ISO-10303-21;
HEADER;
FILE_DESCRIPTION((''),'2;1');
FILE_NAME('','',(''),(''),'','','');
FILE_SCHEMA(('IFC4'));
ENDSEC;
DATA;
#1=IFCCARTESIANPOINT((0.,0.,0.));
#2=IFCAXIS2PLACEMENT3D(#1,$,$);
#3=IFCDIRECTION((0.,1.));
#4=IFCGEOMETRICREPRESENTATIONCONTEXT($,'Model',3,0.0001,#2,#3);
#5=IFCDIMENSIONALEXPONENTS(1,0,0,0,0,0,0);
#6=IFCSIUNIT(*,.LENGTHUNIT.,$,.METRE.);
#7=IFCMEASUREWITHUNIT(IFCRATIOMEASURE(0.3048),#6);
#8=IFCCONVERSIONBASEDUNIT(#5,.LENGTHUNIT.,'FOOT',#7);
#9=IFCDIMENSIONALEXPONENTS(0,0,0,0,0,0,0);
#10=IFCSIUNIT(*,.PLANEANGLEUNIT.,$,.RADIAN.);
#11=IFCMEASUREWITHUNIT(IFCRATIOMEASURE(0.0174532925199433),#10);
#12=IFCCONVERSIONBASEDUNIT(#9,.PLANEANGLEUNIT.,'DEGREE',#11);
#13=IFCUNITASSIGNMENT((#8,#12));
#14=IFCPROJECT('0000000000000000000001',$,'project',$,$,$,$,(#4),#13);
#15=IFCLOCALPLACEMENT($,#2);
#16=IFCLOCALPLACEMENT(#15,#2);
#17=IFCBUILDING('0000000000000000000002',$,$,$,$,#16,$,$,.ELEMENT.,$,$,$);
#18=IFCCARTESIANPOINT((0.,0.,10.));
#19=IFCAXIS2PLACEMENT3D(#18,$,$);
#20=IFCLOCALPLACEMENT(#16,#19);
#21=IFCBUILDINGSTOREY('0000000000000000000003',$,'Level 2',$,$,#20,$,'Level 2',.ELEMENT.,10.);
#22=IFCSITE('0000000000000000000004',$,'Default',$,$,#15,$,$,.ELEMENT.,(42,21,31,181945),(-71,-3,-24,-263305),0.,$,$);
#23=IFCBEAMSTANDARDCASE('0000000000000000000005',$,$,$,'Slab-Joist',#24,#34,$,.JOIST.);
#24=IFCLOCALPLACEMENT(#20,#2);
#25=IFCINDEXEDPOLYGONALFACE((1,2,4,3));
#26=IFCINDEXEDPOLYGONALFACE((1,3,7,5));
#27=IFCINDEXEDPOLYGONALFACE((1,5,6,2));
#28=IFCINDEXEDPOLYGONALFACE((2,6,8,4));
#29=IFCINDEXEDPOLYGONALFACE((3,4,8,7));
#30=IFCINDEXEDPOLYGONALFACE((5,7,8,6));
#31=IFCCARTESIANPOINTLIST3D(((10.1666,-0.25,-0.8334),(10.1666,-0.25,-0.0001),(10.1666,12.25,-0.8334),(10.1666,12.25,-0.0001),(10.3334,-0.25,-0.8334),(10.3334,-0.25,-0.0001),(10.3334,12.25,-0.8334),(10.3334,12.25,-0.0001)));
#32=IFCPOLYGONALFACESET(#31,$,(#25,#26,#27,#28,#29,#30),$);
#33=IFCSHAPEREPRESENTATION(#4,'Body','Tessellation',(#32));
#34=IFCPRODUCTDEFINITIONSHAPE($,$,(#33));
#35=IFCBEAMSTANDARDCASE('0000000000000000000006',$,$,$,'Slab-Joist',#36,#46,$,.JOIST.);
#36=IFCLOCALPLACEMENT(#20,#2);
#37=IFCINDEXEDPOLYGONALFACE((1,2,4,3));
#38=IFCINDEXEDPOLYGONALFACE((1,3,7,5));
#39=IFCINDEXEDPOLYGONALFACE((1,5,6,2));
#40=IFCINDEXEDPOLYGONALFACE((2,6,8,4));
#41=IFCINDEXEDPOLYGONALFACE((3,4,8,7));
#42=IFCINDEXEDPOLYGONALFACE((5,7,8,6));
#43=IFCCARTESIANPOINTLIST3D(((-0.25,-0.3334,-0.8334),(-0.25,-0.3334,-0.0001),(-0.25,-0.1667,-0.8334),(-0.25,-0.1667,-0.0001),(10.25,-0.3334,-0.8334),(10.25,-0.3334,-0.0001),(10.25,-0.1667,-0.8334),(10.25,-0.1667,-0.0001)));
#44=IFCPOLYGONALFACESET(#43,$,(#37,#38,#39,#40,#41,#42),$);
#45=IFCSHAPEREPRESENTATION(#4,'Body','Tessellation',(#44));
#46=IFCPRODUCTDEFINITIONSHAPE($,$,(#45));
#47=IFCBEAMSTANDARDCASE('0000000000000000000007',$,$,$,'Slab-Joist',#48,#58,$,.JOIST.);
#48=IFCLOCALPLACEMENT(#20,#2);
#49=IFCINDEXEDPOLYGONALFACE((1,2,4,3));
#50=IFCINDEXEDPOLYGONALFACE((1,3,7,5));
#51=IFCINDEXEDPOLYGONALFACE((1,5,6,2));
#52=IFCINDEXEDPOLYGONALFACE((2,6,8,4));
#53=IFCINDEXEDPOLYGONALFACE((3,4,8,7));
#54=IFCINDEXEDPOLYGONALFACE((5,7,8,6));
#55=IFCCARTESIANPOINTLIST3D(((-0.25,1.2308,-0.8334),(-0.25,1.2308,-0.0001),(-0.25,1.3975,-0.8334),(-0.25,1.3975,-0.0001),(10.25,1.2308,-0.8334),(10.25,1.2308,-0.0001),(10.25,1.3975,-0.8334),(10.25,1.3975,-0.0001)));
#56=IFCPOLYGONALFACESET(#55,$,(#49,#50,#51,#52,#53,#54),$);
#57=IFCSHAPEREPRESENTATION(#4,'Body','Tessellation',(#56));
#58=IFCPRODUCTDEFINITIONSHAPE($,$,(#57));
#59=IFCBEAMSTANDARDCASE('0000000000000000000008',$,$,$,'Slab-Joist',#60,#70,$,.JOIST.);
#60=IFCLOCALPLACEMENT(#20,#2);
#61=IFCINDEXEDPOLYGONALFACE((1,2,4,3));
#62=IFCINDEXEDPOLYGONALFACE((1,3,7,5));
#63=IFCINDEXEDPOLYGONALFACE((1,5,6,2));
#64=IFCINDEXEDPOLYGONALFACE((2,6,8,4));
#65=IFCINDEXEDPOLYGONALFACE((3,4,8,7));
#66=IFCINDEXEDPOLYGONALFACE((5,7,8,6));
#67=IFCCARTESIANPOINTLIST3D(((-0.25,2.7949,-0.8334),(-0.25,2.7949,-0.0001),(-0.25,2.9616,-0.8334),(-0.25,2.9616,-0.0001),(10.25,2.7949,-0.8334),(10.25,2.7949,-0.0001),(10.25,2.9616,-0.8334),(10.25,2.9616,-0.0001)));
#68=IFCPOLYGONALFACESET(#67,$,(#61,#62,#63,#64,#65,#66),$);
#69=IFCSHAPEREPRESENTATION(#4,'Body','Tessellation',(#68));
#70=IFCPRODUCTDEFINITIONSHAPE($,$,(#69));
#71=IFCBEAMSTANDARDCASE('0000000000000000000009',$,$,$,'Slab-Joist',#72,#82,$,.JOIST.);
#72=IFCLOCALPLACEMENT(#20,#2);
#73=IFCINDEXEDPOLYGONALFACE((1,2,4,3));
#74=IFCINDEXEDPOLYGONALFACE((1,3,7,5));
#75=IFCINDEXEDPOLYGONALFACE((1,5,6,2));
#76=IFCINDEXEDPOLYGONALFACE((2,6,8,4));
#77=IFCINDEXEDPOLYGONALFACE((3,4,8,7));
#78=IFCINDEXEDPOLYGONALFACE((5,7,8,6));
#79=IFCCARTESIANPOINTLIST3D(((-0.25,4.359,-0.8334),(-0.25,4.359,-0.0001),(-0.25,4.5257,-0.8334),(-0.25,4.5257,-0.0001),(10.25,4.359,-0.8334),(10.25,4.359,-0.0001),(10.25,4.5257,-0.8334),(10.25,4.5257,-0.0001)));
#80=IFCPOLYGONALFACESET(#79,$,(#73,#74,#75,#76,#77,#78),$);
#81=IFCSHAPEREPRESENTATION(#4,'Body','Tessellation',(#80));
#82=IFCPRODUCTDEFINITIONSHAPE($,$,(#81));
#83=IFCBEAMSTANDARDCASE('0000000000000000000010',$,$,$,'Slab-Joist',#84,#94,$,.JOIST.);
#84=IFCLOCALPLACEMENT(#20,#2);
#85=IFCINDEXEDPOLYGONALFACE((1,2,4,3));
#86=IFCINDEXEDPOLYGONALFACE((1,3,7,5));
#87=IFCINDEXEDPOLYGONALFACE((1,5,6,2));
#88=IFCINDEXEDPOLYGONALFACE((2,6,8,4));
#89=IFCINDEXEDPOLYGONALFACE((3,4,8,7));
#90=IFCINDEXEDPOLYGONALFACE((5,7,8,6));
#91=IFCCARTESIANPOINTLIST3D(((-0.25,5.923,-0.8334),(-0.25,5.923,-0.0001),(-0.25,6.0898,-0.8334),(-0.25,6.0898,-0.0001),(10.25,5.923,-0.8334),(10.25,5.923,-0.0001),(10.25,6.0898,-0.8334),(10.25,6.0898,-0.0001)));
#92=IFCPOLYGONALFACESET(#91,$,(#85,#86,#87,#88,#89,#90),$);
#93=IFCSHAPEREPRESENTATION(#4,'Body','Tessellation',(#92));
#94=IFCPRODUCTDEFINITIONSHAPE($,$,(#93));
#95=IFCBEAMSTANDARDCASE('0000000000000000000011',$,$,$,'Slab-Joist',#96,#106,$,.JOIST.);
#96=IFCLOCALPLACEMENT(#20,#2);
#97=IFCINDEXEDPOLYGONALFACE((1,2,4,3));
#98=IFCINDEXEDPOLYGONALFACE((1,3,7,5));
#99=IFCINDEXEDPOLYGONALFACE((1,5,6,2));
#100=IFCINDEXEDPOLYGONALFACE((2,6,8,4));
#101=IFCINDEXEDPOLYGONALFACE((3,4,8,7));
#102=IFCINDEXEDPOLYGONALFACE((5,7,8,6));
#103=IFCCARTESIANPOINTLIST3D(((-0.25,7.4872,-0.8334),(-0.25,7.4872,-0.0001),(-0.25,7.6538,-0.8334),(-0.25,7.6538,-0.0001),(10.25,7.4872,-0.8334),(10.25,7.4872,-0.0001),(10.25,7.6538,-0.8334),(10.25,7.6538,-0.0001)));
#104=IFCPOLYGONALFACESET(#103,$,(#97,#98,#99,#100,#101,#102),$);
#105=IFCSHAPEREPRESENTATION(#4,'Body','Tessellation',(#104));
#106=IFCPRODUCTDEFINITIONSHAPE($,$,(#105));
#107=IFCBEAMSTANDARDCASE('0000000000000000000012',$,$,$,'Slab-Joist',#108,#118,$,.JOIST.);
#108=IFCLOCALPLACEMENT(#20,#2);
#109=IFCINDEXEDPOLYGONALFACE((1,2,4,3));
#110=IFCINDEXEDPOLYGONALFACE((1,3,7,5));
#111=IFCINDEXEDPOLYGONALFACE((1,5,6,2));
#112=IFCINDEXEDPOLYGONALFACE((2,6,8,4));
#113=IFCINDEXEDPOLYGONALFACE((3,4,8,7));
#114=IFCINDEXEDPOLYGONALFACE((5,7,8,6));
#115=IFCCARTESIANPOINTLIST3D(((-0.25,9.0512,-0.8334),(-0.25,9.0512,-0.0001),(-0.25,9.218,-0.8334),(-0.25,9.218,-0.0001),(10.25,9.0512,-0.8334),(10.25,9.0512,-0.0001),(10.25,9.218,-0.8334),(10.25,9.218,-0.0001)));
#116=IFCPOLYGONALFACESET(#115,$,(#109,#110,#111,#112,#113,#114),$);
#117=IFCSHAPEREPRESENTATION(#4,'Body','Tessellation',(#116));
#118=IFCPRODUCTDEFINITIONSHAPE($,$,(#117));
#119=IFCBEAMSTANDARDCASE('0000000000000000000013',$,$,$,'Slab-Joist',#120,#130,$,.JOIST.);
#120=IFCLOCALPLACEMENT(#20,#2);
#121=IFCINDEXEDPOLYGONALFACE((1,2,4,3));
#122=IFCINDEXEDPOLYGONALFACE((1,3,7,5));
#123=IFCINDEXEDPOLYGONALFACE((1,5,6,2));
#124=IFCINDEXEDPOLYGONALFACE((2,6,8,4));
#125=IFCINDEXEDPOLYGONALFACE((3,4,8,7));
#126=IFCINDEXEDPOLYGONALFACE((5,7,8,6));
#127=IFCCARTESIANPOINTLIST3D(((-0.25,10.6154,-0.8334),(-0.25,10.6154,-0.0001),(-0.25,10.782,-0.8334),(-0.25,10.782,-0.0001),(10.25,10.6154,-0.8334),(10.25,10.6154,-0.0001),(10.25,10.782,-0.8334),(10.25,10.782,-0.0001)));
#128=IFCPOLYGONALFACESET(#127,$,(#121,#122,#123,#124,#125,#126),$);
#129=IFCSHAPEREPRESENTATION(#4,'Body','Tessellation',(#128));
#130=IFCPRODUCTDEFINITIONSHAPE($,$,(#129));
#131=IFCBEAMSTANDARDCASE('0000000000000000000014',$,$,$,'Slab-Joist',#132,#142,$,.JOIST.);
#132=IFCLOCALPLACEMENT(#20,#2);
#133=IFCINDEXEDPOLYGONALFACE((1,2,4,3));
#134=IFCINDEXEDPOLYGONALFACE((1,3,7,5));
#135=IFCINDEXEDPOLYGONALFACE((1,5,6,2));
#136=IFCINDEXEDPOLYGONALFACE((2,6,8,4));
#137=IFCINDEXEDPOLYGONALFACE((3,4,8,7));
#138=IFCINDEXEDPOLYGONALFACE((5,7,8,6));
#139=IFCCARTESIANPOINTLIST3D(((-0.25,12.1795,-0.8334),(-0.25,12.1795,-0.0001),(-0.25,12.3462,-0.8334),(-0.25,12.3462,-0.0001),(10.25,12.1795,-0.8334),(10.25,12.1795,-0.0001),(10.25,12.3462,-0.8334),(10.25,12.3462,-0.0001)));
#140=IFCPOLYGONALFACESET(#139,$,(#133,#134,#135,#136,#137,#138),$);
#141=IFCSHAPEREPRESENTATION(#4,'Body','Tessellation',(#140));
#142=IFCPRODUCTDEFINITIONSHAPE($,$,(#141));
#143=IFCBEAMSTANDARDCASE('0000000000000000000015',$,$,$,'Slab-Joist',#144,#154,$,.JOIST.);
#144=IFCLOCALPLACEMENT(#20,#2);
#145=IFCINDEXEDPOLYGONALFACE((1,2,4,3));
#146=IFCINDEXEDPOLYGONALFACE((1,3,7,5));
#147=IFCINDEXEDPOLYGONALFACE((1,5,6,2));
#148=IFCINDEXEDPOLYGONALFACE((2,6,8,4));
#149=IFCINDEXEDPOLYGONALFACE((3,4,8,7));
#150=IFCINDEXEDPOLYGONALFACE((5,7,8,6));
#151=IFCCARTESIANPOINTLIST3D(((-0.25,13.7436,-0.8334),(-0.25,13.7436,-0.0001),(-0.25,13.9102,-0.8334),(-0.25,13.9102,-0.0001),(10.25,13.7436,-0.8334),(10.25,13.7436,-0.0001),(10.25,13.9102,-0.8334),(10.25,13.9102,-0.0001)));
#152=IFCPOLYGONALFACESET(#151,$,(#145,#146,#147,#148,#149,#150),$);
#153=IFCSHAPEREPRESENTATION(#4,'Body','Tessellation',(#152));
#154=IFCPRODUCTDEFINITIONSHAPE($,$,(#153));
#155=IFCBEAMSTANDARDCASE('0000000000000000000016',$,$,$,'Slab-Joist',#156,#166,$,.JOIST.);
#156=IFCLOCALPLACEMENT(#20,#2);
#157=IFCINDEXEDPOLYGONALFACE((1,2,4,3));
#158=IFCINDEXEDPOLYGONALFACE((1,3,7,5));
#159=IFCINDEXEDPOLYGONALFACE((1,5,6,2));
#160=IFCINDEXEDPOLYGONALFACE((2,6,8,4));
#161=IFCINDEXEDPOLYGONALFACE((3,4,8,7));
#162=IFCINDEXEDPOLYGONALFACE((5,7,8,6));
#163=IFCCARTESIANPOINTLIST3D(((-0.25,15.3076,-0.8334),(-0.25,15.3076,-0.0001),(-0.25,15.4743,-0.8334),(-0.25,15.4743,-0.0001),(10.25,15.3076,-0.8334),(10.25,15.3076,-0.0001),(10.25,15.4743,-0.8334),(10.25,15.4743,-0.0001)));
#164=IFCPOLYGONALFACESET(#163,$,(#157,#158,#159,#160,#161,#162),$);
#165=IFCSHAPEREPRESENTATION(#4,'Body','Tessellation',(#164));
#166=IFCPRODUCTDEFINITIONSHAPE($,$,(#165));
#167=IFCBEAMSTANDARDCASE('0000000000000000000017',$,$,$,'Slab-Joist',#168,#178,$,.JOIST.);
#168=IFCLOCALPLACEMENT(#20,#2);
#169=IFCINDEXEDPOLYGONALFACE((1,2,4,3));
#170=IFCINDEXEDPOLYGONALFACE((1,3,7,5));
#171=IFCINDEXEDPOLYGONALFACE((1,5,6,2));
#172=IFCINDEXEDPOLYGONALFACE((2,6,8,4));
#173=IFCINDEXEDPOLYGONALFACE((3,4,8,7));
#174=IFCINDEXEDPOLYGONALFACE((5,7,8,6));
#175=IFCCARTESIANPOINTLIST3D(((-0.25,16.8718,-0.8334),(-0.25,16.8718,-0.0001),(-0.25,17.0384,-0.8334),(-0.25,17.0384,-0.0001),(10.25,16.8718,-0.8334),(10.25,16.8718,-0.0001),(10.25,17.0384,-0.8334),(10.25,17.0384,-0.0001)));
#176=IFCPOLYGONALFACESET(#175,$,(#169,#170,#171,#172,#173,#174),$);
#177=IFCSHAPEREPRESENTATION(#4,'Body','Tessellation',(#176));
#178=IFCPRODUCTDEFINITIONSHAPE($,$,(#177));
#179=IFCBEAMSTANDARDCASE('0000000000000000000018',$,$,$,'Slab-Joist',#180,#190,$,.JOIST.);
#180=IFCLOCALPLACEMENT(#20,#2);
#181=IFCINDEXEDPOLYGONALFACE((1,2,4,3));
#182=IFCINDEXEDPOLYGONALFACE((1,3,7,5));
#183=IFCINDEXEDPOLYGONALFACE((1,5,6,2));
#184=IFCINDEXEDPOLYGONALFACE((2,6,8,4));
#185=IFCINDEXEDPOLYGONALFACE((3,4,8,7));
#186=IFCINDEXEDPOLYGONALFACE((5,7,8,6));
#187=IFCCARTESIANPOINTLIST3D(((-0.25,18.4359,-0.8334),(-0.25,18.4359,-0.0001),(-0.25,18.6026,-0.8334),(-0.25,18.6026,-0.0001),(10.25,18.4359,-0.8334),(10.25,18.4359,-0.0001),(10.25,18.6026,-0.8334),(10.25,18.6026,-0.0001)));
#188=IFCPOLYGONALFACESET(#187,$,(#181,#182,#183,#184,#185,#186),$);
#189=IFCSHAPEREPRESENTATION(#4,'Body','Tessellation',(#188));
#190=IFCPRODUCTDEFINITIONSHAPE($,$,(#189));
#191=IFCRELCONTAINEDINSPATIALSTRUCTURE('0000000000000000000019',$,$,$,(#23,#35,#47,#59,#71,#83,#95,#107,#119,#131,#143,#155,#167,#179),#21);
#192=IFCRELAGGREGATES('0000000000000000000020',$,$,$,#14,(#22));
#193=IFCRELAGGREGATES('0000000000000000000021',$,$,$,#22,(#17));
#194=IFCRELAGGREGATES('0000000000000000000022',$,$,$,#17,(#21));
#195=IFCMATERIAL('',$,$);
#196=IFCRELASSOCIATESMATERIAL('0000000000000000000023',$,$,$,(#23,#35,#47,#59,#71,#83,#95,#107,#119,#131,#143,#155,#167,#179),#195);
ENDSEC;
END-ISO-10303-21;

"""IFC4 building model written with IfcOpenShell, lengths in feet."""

from ifc_helpers import new_model, entity, si_unit, converted_unit, direction, frame, origin, origin_with_axes, place, context, project, spatial, rectangle, extrude, material, element, save


model = new_model("IFC4")

# Units and contexts
model_context = context("Model", 3, precision=0.0001, world=origin(), true_north=direction((0.0, 1.0)))
ifc_project = project(units=[converted_unit("LENGTHUNIT", "FOOT", entity("IfcRatioMeasure", 0.3048), si_unit("LENGTHUNIT", "METRE"), dimensions=[1, 0, 0, 0, 0, 0, 0]), converted_unit("PLANEANGLEUNIT", "DEGREE", entity("IfcRatioMeasure", 0.0174532925199433), si_unit("PLANEANGLEUNIT", "RADIAN"), dimensions=[0, 0, 0, 0, 0, 0, 0])], contexts=[model_context])

# Site, building, storey
site_placement = place(None, origin())
site = spatial("IfcSite", under=ifc_project, at=site_placement, Name="Default", CompositionType="ELEMENT", RefLatitude=(42, 21, 31, 181945), RefLongitude=(-71, -3, -24, -263305), RefElevation=0.0)
building_placement = place(site_placement, origin())
building = spatial("IfcBuilding", under=site, at=building_placement, CompositionType="ELEMENT")
storey_placement = place(building_placement, frame((0.0, 0.0, 10.0)))
storey = spatial("IfcBuildingStorey", under=building, at=storey_placement, Name="Level 2", LongName="Level 2", CompositionType="ELEMENT", Elevation=10.0)

# Beams
ifc_material = material(Name="")
placement_1 = place(storey_placement, frame((10.25, -0.25, 0.0), z_axis=(0.0, 0.0, 1.0), x_axis=(1.0, 0.0, 0.0)))
beam_1_placement = place(placement_1, frame((0.0, 0.0, -0.4167), z_axis=(0.0, 1.0, 0.0), x_axis=(-1.0, 0.0, 0.0)))
element("IfcBeamStandardCase", 1, at=beam_1_placement, inside=storey, material=ifc_material, ObjectType="Slab-Joist", PredefinedType="JOIST", context=model_context, shape_type="SweptSolid", body=[
    extrude(rectangle(XDim=0.1667, YDim=0.8333), origin_with_axes(), (0.0, 0.0, 1.0), 12.5),
])
placement_2 = place(storey_placement, frame((-0.25, -0.25, 0.0), z_axis=(0.0, 0.0, 1.0), x_axis=(1.0, 0.0, 0.0)))
beam_2_placement = place(placement_2, frame((0.0, 0.0, -0.4167), z_axis=(1.0, 0.0, 0.0), x_axis=(0.0, 1.0, 0.0)))
element("IfcBeamStandardCase", 2, at=beam_2_placement, inside=storey, material=ifc_material, ObjectType="Slab-Joist", PredefinedType="JOIST", context=model_context, shape_type="SweptSolid", body=[
    extrude(rectangle(XDim=0.1667, YDim=0.8333), origin_with_axes(), (0.0, 0.0, 1.0), 10.5),
])
placement_3 = place(storey_placement, frame((-0.25, -0.25, 0.0), z_axis=(0.0, 0.0, 1.0), x_axis=(1.0, 0.0, 0.0)))
beam_3_placement = place(placement_3, frame((0.0, 1.5641, -0.4167), z_axis=(1.0, 0.0, 0.0), x_axis=(0.0, 1.0, 0.0)))
element("IfcBeamStandardCase", 3, at=beam_3_placement, inside=storey, material=ifc_material, ObjectType="Slab-Joist", PredefinedType="JOIST", context=model_context, shape_type="SweptSolid", body=[
    extrude(rectangle(XDim=0.1667, YDim=0.8333), origin_with_axes(), (0.0, 0.0, 1.0), 10.5),
])
placement_4 = place(storey_placement, frame((-0.25, -0.25, 0.0), z_axis=(0.0, 0.0, 1.0), x_axis=(1.0, 0.0, 0.0)))
beam_4_placement = place(placement_4, frame((0.0, 3.1282, -0.4167), z_axis=(1.0, 0.0, 0.0), x_axis=(0.0, 1.0, 0.0)))
element("IfcBeamStandardCase", 4, at=beam_4_placement, inside=storey, material=ifc_material, ObjectType="Slab-Joist", PredefinedType="JOIST", context=model_context, shape_type="SweptSolid", body=[
    extrude(rectangle(XDim=0.1667, YDim=0.8333), origin_with_axes(), (0.0, 0.0, 1.0), 10.5),
])
placement_5 = place(storey_placement, frame((-0.25, -0.25, 0.0), z_axis=(0.0, 0.0, 1.0), x_axis=(1.0, 0.0, 0.0)))
beam_5_placement = place(placement_5, frame((0.0, 4.6923, -0.4167), z_axis=(1.0, 0.0, 0.0), x_axis=(0.0, 1.0, 0.0)))
element("IfcBeamStandardCase", 5, at=beam_5_placement, inside=storey, material=ifc_material, ObjectType="Slab-Joist", PredefinedType="JOIST", context=model_context, shape_type="SweptSolid", body=[
    extrude(rectangle(XDim=0.1667, YDim=0.8333), origin_with_axes(), (0.0, 0.0, 1.0), 10.5),
])
placement_6 = place(storey_placement, frame((-0.25, -0.25, 0.0), z_axis=(0.0, 0.0, 1.0), x_axis=(1.0, 0.0, 0.0)))
beam_6_placement = place(placement_6, frame((0.0, 6.2564, -0.4167), z_axis=(1.0, 0.0, 0.0), x_axis=(0.0, 1.0, 0.0)))
element("IfcBeamStandardCase", 6, at=beam_6_placement, inside=storey, material=ifc_material, ObjectType="Slab-Joist", PredefinedType="JOIST", context=model_context, shape_type="SweptSolid", body=[
    extrude(rectangle(XDim=0.1667, YDim=0.8333), origin_with_axes(), (0.0, 0.0, 1.0), 10.5),
])
placement_7 = place(storey_placement, frame((-0.25, -0.25, 0.0), z_axis=(0.0, 0.0, 1.0), x_axis=(1.0, 0.0, 0.0)))
beam_7_placement = place(placement_7, frame((0.0, 7.8205, -0.4167), z_axis=(1.0, 0.0, 0.0), x_axis=(0.0, 1.0, 0.0)))
element("IfcBeamStandardCase", 7, at=beam_7_placement, inside=storey, material=ifc_material, ObjectType="Slab-Joist", PredefinedType="JOIST", context=model_context, shape_type="SweptSolid", body=[
    extrude(rectangle(XDim=0.1667, YDim=0.8333), origin_with_axes(), (0.0, 0.0, 1.0), 10.5),
])
placement_8 = place(storey_placement, frame((-0.25, -0.25, 0.0), z_axis=(0.0, 0.0, 1.0), x_axis=(1.0, 0.0, 0.0)))
beam_8_placement = place(placement_8, frame((0.0, 9.3846, -0.4167), z_axis=(1.0, 0.0, 0.0), x_axis=(0.0, 1.0, 0.0)))
element("IfcBeamStandardCase", 8, at=beam_8_placement, inside=storey, material=ifc_material, ObjectType="Slab-Joist", PredefinedType="JOIST", context=model_context, shape_type="SweptSolid", body=[
    extrude(rectangle(XDim=0.1667, YDim=0.8333), origin_with_axes(), (0.0, 0.0, 1.0), 10.5),
])
placement_9 = place(storey_placement, frame((-0.25, -0.25, 0.0), z_axis=(0.0, 0.0, 1.0), x_axis=(1.0, 0.0, 0.0)))
beam_9_placement = place(placement_9, frame((0.0, 10.9487, -0.4167), z_axis=(1.0, 0.0, 0.0), x_axis=(0.0, 1.0, 0.0)))
element("IfcBeamStandardCase", 9, at=beam_9_placement, inside=storey, material=ifc_material, ObjectType="Slab-Joist", PredefinedType="JOIST", context=model_context, shape_type="SweptSolid", body=[
    extrude(rectangle(XDim=0.1667, YDim=0.8333), origin_with_axes(), (0.0, 0.0, 1.0), 10.5),
])
placement_10 = place(storey_placement, frame((-0.25, -0.25, 0.0), z_axis=(0.0, 0.0, 1.0), x_axis=(1.0, 0.0, 0.0)))
beam_10_placement = place(placement_10, frame((0.0, 12.5128, -0.4167), z_axis=(1.0, 0.0, 0.0), x_axis=(0.0, 1.0, 0.0)))
element("IfcBeamStandardCase", 10, at=beam_10_placement, inside=storey, material=ifc_material, ObjectType="Slab-Joist", PredefinedType="JOIST", context=model_context, shape_type="SweptSolid", body=[
    extrude(rectangle(XDim=0.1667, YDim=0.8333), origin_with_axes(), (0.0, 0.0, 1.0), 10.5),
])
placement_11 = place(storey_placement, frame((-0.25, -0.25, 0.0), z_axis=(0.0, 0.0, 1.0), x_axis=(1.0, 0.0, 0.0)))
beam_11_placement = place(placement_11, frame((0.0, 14.0769, -0.4167), z_axis=(1.0, 0.0, 0.0), x_axis=(0.0, 1.0, 0.0)))
element("IfcBeamStandardCase", 11, at=beam_11_placement, inside=storey, material=ifc_material, ObjectType="Slab-Joist", PredefinedType="JOIST", context=model_context, shape_type="SweptSolid", body=[
    extrude(rectangle(XDim=0.1667, YDim=0.8333), origin_with_axes(), (0.0, 0.0, 1.0), 10.5),
])
placement_12 = place(storey_placement, frame((-0.25, -0.25, 0.0), z_axis=(0.0, 0.0, 1.0), x_axis=(1.0, 0.0, 0.0)))
beam_12_placement = place(placement_12, frame((0.0, 15.641, -0.4167), z_axis=(1.0, 0.0, 0.0), x_axis=(0.0, 1.0, 0.0)))
element("IfcBeamStandardCase", 12, at=beam_12_placement, inside=storey, material=ifc_material, ObjectType="Slab-Joist", PredefinedType="JOIST", context=model_context, shape_type="SweptSolid", body=[
    extrude(rectangle(XDim=0.1667, YDim=0.8333), origin_with_axes(), (0.0, 0.0, 1.0), 10.5),
])
placement_13 = place(storey_placement, frame((-0.25, -0.25, 0.0), z_axis=(0.0, 0.0, 1.0), x_axis=(1.0, 0.0, 0.0)))
beam_13_placement = place(placement_13, frame((0.0, 17.2051, -0.4167), z_axis=(1.0, 0.0, 0.0), x_axis=(0.0, 1.0, 0.0)))
element("IfcBeamStandardCase", 13, at=beam_13_placement, inside=storey, material=ifc_material, ObjectType="Slab-Joist", PredefinedType="JOIST", context=model_context, shape_type="SweptSolid", body=[
    extrude(rectangle(XDim=0.1667, YDim=0.8333), origin_with_axes(), (0.0, 0.0, 1.0), 10.5),
])
placement_14 = place(storey_placement, frame((-0.25, -0.25, 0.0), z_axis=(0.0, 0.0, 1.0), x_axis=(1.0, 0.0, 0.0)))
beam_14_placement = place(placement_14, frame((0.0, 18.7692, -0.4167), z_axis=(1.0, 0.0, 0.0), x_axis=(0.0, 1.0, 0.0)))
element("IfcBeamStandardCase", 14, at=beam_14_placement, inside=storey, material=ifc_material, ObjectType="Slab-Joist", PredefinedType="JOIST", context=model_context, shape_type="SweptSolid", body=[
    extrude(rectangle(XDim=0.1667, YDim=0.8333), origin_with_axes(), (0.0, 0.0, 1.0), 10.5),
])

save(model, "model.ifc")
